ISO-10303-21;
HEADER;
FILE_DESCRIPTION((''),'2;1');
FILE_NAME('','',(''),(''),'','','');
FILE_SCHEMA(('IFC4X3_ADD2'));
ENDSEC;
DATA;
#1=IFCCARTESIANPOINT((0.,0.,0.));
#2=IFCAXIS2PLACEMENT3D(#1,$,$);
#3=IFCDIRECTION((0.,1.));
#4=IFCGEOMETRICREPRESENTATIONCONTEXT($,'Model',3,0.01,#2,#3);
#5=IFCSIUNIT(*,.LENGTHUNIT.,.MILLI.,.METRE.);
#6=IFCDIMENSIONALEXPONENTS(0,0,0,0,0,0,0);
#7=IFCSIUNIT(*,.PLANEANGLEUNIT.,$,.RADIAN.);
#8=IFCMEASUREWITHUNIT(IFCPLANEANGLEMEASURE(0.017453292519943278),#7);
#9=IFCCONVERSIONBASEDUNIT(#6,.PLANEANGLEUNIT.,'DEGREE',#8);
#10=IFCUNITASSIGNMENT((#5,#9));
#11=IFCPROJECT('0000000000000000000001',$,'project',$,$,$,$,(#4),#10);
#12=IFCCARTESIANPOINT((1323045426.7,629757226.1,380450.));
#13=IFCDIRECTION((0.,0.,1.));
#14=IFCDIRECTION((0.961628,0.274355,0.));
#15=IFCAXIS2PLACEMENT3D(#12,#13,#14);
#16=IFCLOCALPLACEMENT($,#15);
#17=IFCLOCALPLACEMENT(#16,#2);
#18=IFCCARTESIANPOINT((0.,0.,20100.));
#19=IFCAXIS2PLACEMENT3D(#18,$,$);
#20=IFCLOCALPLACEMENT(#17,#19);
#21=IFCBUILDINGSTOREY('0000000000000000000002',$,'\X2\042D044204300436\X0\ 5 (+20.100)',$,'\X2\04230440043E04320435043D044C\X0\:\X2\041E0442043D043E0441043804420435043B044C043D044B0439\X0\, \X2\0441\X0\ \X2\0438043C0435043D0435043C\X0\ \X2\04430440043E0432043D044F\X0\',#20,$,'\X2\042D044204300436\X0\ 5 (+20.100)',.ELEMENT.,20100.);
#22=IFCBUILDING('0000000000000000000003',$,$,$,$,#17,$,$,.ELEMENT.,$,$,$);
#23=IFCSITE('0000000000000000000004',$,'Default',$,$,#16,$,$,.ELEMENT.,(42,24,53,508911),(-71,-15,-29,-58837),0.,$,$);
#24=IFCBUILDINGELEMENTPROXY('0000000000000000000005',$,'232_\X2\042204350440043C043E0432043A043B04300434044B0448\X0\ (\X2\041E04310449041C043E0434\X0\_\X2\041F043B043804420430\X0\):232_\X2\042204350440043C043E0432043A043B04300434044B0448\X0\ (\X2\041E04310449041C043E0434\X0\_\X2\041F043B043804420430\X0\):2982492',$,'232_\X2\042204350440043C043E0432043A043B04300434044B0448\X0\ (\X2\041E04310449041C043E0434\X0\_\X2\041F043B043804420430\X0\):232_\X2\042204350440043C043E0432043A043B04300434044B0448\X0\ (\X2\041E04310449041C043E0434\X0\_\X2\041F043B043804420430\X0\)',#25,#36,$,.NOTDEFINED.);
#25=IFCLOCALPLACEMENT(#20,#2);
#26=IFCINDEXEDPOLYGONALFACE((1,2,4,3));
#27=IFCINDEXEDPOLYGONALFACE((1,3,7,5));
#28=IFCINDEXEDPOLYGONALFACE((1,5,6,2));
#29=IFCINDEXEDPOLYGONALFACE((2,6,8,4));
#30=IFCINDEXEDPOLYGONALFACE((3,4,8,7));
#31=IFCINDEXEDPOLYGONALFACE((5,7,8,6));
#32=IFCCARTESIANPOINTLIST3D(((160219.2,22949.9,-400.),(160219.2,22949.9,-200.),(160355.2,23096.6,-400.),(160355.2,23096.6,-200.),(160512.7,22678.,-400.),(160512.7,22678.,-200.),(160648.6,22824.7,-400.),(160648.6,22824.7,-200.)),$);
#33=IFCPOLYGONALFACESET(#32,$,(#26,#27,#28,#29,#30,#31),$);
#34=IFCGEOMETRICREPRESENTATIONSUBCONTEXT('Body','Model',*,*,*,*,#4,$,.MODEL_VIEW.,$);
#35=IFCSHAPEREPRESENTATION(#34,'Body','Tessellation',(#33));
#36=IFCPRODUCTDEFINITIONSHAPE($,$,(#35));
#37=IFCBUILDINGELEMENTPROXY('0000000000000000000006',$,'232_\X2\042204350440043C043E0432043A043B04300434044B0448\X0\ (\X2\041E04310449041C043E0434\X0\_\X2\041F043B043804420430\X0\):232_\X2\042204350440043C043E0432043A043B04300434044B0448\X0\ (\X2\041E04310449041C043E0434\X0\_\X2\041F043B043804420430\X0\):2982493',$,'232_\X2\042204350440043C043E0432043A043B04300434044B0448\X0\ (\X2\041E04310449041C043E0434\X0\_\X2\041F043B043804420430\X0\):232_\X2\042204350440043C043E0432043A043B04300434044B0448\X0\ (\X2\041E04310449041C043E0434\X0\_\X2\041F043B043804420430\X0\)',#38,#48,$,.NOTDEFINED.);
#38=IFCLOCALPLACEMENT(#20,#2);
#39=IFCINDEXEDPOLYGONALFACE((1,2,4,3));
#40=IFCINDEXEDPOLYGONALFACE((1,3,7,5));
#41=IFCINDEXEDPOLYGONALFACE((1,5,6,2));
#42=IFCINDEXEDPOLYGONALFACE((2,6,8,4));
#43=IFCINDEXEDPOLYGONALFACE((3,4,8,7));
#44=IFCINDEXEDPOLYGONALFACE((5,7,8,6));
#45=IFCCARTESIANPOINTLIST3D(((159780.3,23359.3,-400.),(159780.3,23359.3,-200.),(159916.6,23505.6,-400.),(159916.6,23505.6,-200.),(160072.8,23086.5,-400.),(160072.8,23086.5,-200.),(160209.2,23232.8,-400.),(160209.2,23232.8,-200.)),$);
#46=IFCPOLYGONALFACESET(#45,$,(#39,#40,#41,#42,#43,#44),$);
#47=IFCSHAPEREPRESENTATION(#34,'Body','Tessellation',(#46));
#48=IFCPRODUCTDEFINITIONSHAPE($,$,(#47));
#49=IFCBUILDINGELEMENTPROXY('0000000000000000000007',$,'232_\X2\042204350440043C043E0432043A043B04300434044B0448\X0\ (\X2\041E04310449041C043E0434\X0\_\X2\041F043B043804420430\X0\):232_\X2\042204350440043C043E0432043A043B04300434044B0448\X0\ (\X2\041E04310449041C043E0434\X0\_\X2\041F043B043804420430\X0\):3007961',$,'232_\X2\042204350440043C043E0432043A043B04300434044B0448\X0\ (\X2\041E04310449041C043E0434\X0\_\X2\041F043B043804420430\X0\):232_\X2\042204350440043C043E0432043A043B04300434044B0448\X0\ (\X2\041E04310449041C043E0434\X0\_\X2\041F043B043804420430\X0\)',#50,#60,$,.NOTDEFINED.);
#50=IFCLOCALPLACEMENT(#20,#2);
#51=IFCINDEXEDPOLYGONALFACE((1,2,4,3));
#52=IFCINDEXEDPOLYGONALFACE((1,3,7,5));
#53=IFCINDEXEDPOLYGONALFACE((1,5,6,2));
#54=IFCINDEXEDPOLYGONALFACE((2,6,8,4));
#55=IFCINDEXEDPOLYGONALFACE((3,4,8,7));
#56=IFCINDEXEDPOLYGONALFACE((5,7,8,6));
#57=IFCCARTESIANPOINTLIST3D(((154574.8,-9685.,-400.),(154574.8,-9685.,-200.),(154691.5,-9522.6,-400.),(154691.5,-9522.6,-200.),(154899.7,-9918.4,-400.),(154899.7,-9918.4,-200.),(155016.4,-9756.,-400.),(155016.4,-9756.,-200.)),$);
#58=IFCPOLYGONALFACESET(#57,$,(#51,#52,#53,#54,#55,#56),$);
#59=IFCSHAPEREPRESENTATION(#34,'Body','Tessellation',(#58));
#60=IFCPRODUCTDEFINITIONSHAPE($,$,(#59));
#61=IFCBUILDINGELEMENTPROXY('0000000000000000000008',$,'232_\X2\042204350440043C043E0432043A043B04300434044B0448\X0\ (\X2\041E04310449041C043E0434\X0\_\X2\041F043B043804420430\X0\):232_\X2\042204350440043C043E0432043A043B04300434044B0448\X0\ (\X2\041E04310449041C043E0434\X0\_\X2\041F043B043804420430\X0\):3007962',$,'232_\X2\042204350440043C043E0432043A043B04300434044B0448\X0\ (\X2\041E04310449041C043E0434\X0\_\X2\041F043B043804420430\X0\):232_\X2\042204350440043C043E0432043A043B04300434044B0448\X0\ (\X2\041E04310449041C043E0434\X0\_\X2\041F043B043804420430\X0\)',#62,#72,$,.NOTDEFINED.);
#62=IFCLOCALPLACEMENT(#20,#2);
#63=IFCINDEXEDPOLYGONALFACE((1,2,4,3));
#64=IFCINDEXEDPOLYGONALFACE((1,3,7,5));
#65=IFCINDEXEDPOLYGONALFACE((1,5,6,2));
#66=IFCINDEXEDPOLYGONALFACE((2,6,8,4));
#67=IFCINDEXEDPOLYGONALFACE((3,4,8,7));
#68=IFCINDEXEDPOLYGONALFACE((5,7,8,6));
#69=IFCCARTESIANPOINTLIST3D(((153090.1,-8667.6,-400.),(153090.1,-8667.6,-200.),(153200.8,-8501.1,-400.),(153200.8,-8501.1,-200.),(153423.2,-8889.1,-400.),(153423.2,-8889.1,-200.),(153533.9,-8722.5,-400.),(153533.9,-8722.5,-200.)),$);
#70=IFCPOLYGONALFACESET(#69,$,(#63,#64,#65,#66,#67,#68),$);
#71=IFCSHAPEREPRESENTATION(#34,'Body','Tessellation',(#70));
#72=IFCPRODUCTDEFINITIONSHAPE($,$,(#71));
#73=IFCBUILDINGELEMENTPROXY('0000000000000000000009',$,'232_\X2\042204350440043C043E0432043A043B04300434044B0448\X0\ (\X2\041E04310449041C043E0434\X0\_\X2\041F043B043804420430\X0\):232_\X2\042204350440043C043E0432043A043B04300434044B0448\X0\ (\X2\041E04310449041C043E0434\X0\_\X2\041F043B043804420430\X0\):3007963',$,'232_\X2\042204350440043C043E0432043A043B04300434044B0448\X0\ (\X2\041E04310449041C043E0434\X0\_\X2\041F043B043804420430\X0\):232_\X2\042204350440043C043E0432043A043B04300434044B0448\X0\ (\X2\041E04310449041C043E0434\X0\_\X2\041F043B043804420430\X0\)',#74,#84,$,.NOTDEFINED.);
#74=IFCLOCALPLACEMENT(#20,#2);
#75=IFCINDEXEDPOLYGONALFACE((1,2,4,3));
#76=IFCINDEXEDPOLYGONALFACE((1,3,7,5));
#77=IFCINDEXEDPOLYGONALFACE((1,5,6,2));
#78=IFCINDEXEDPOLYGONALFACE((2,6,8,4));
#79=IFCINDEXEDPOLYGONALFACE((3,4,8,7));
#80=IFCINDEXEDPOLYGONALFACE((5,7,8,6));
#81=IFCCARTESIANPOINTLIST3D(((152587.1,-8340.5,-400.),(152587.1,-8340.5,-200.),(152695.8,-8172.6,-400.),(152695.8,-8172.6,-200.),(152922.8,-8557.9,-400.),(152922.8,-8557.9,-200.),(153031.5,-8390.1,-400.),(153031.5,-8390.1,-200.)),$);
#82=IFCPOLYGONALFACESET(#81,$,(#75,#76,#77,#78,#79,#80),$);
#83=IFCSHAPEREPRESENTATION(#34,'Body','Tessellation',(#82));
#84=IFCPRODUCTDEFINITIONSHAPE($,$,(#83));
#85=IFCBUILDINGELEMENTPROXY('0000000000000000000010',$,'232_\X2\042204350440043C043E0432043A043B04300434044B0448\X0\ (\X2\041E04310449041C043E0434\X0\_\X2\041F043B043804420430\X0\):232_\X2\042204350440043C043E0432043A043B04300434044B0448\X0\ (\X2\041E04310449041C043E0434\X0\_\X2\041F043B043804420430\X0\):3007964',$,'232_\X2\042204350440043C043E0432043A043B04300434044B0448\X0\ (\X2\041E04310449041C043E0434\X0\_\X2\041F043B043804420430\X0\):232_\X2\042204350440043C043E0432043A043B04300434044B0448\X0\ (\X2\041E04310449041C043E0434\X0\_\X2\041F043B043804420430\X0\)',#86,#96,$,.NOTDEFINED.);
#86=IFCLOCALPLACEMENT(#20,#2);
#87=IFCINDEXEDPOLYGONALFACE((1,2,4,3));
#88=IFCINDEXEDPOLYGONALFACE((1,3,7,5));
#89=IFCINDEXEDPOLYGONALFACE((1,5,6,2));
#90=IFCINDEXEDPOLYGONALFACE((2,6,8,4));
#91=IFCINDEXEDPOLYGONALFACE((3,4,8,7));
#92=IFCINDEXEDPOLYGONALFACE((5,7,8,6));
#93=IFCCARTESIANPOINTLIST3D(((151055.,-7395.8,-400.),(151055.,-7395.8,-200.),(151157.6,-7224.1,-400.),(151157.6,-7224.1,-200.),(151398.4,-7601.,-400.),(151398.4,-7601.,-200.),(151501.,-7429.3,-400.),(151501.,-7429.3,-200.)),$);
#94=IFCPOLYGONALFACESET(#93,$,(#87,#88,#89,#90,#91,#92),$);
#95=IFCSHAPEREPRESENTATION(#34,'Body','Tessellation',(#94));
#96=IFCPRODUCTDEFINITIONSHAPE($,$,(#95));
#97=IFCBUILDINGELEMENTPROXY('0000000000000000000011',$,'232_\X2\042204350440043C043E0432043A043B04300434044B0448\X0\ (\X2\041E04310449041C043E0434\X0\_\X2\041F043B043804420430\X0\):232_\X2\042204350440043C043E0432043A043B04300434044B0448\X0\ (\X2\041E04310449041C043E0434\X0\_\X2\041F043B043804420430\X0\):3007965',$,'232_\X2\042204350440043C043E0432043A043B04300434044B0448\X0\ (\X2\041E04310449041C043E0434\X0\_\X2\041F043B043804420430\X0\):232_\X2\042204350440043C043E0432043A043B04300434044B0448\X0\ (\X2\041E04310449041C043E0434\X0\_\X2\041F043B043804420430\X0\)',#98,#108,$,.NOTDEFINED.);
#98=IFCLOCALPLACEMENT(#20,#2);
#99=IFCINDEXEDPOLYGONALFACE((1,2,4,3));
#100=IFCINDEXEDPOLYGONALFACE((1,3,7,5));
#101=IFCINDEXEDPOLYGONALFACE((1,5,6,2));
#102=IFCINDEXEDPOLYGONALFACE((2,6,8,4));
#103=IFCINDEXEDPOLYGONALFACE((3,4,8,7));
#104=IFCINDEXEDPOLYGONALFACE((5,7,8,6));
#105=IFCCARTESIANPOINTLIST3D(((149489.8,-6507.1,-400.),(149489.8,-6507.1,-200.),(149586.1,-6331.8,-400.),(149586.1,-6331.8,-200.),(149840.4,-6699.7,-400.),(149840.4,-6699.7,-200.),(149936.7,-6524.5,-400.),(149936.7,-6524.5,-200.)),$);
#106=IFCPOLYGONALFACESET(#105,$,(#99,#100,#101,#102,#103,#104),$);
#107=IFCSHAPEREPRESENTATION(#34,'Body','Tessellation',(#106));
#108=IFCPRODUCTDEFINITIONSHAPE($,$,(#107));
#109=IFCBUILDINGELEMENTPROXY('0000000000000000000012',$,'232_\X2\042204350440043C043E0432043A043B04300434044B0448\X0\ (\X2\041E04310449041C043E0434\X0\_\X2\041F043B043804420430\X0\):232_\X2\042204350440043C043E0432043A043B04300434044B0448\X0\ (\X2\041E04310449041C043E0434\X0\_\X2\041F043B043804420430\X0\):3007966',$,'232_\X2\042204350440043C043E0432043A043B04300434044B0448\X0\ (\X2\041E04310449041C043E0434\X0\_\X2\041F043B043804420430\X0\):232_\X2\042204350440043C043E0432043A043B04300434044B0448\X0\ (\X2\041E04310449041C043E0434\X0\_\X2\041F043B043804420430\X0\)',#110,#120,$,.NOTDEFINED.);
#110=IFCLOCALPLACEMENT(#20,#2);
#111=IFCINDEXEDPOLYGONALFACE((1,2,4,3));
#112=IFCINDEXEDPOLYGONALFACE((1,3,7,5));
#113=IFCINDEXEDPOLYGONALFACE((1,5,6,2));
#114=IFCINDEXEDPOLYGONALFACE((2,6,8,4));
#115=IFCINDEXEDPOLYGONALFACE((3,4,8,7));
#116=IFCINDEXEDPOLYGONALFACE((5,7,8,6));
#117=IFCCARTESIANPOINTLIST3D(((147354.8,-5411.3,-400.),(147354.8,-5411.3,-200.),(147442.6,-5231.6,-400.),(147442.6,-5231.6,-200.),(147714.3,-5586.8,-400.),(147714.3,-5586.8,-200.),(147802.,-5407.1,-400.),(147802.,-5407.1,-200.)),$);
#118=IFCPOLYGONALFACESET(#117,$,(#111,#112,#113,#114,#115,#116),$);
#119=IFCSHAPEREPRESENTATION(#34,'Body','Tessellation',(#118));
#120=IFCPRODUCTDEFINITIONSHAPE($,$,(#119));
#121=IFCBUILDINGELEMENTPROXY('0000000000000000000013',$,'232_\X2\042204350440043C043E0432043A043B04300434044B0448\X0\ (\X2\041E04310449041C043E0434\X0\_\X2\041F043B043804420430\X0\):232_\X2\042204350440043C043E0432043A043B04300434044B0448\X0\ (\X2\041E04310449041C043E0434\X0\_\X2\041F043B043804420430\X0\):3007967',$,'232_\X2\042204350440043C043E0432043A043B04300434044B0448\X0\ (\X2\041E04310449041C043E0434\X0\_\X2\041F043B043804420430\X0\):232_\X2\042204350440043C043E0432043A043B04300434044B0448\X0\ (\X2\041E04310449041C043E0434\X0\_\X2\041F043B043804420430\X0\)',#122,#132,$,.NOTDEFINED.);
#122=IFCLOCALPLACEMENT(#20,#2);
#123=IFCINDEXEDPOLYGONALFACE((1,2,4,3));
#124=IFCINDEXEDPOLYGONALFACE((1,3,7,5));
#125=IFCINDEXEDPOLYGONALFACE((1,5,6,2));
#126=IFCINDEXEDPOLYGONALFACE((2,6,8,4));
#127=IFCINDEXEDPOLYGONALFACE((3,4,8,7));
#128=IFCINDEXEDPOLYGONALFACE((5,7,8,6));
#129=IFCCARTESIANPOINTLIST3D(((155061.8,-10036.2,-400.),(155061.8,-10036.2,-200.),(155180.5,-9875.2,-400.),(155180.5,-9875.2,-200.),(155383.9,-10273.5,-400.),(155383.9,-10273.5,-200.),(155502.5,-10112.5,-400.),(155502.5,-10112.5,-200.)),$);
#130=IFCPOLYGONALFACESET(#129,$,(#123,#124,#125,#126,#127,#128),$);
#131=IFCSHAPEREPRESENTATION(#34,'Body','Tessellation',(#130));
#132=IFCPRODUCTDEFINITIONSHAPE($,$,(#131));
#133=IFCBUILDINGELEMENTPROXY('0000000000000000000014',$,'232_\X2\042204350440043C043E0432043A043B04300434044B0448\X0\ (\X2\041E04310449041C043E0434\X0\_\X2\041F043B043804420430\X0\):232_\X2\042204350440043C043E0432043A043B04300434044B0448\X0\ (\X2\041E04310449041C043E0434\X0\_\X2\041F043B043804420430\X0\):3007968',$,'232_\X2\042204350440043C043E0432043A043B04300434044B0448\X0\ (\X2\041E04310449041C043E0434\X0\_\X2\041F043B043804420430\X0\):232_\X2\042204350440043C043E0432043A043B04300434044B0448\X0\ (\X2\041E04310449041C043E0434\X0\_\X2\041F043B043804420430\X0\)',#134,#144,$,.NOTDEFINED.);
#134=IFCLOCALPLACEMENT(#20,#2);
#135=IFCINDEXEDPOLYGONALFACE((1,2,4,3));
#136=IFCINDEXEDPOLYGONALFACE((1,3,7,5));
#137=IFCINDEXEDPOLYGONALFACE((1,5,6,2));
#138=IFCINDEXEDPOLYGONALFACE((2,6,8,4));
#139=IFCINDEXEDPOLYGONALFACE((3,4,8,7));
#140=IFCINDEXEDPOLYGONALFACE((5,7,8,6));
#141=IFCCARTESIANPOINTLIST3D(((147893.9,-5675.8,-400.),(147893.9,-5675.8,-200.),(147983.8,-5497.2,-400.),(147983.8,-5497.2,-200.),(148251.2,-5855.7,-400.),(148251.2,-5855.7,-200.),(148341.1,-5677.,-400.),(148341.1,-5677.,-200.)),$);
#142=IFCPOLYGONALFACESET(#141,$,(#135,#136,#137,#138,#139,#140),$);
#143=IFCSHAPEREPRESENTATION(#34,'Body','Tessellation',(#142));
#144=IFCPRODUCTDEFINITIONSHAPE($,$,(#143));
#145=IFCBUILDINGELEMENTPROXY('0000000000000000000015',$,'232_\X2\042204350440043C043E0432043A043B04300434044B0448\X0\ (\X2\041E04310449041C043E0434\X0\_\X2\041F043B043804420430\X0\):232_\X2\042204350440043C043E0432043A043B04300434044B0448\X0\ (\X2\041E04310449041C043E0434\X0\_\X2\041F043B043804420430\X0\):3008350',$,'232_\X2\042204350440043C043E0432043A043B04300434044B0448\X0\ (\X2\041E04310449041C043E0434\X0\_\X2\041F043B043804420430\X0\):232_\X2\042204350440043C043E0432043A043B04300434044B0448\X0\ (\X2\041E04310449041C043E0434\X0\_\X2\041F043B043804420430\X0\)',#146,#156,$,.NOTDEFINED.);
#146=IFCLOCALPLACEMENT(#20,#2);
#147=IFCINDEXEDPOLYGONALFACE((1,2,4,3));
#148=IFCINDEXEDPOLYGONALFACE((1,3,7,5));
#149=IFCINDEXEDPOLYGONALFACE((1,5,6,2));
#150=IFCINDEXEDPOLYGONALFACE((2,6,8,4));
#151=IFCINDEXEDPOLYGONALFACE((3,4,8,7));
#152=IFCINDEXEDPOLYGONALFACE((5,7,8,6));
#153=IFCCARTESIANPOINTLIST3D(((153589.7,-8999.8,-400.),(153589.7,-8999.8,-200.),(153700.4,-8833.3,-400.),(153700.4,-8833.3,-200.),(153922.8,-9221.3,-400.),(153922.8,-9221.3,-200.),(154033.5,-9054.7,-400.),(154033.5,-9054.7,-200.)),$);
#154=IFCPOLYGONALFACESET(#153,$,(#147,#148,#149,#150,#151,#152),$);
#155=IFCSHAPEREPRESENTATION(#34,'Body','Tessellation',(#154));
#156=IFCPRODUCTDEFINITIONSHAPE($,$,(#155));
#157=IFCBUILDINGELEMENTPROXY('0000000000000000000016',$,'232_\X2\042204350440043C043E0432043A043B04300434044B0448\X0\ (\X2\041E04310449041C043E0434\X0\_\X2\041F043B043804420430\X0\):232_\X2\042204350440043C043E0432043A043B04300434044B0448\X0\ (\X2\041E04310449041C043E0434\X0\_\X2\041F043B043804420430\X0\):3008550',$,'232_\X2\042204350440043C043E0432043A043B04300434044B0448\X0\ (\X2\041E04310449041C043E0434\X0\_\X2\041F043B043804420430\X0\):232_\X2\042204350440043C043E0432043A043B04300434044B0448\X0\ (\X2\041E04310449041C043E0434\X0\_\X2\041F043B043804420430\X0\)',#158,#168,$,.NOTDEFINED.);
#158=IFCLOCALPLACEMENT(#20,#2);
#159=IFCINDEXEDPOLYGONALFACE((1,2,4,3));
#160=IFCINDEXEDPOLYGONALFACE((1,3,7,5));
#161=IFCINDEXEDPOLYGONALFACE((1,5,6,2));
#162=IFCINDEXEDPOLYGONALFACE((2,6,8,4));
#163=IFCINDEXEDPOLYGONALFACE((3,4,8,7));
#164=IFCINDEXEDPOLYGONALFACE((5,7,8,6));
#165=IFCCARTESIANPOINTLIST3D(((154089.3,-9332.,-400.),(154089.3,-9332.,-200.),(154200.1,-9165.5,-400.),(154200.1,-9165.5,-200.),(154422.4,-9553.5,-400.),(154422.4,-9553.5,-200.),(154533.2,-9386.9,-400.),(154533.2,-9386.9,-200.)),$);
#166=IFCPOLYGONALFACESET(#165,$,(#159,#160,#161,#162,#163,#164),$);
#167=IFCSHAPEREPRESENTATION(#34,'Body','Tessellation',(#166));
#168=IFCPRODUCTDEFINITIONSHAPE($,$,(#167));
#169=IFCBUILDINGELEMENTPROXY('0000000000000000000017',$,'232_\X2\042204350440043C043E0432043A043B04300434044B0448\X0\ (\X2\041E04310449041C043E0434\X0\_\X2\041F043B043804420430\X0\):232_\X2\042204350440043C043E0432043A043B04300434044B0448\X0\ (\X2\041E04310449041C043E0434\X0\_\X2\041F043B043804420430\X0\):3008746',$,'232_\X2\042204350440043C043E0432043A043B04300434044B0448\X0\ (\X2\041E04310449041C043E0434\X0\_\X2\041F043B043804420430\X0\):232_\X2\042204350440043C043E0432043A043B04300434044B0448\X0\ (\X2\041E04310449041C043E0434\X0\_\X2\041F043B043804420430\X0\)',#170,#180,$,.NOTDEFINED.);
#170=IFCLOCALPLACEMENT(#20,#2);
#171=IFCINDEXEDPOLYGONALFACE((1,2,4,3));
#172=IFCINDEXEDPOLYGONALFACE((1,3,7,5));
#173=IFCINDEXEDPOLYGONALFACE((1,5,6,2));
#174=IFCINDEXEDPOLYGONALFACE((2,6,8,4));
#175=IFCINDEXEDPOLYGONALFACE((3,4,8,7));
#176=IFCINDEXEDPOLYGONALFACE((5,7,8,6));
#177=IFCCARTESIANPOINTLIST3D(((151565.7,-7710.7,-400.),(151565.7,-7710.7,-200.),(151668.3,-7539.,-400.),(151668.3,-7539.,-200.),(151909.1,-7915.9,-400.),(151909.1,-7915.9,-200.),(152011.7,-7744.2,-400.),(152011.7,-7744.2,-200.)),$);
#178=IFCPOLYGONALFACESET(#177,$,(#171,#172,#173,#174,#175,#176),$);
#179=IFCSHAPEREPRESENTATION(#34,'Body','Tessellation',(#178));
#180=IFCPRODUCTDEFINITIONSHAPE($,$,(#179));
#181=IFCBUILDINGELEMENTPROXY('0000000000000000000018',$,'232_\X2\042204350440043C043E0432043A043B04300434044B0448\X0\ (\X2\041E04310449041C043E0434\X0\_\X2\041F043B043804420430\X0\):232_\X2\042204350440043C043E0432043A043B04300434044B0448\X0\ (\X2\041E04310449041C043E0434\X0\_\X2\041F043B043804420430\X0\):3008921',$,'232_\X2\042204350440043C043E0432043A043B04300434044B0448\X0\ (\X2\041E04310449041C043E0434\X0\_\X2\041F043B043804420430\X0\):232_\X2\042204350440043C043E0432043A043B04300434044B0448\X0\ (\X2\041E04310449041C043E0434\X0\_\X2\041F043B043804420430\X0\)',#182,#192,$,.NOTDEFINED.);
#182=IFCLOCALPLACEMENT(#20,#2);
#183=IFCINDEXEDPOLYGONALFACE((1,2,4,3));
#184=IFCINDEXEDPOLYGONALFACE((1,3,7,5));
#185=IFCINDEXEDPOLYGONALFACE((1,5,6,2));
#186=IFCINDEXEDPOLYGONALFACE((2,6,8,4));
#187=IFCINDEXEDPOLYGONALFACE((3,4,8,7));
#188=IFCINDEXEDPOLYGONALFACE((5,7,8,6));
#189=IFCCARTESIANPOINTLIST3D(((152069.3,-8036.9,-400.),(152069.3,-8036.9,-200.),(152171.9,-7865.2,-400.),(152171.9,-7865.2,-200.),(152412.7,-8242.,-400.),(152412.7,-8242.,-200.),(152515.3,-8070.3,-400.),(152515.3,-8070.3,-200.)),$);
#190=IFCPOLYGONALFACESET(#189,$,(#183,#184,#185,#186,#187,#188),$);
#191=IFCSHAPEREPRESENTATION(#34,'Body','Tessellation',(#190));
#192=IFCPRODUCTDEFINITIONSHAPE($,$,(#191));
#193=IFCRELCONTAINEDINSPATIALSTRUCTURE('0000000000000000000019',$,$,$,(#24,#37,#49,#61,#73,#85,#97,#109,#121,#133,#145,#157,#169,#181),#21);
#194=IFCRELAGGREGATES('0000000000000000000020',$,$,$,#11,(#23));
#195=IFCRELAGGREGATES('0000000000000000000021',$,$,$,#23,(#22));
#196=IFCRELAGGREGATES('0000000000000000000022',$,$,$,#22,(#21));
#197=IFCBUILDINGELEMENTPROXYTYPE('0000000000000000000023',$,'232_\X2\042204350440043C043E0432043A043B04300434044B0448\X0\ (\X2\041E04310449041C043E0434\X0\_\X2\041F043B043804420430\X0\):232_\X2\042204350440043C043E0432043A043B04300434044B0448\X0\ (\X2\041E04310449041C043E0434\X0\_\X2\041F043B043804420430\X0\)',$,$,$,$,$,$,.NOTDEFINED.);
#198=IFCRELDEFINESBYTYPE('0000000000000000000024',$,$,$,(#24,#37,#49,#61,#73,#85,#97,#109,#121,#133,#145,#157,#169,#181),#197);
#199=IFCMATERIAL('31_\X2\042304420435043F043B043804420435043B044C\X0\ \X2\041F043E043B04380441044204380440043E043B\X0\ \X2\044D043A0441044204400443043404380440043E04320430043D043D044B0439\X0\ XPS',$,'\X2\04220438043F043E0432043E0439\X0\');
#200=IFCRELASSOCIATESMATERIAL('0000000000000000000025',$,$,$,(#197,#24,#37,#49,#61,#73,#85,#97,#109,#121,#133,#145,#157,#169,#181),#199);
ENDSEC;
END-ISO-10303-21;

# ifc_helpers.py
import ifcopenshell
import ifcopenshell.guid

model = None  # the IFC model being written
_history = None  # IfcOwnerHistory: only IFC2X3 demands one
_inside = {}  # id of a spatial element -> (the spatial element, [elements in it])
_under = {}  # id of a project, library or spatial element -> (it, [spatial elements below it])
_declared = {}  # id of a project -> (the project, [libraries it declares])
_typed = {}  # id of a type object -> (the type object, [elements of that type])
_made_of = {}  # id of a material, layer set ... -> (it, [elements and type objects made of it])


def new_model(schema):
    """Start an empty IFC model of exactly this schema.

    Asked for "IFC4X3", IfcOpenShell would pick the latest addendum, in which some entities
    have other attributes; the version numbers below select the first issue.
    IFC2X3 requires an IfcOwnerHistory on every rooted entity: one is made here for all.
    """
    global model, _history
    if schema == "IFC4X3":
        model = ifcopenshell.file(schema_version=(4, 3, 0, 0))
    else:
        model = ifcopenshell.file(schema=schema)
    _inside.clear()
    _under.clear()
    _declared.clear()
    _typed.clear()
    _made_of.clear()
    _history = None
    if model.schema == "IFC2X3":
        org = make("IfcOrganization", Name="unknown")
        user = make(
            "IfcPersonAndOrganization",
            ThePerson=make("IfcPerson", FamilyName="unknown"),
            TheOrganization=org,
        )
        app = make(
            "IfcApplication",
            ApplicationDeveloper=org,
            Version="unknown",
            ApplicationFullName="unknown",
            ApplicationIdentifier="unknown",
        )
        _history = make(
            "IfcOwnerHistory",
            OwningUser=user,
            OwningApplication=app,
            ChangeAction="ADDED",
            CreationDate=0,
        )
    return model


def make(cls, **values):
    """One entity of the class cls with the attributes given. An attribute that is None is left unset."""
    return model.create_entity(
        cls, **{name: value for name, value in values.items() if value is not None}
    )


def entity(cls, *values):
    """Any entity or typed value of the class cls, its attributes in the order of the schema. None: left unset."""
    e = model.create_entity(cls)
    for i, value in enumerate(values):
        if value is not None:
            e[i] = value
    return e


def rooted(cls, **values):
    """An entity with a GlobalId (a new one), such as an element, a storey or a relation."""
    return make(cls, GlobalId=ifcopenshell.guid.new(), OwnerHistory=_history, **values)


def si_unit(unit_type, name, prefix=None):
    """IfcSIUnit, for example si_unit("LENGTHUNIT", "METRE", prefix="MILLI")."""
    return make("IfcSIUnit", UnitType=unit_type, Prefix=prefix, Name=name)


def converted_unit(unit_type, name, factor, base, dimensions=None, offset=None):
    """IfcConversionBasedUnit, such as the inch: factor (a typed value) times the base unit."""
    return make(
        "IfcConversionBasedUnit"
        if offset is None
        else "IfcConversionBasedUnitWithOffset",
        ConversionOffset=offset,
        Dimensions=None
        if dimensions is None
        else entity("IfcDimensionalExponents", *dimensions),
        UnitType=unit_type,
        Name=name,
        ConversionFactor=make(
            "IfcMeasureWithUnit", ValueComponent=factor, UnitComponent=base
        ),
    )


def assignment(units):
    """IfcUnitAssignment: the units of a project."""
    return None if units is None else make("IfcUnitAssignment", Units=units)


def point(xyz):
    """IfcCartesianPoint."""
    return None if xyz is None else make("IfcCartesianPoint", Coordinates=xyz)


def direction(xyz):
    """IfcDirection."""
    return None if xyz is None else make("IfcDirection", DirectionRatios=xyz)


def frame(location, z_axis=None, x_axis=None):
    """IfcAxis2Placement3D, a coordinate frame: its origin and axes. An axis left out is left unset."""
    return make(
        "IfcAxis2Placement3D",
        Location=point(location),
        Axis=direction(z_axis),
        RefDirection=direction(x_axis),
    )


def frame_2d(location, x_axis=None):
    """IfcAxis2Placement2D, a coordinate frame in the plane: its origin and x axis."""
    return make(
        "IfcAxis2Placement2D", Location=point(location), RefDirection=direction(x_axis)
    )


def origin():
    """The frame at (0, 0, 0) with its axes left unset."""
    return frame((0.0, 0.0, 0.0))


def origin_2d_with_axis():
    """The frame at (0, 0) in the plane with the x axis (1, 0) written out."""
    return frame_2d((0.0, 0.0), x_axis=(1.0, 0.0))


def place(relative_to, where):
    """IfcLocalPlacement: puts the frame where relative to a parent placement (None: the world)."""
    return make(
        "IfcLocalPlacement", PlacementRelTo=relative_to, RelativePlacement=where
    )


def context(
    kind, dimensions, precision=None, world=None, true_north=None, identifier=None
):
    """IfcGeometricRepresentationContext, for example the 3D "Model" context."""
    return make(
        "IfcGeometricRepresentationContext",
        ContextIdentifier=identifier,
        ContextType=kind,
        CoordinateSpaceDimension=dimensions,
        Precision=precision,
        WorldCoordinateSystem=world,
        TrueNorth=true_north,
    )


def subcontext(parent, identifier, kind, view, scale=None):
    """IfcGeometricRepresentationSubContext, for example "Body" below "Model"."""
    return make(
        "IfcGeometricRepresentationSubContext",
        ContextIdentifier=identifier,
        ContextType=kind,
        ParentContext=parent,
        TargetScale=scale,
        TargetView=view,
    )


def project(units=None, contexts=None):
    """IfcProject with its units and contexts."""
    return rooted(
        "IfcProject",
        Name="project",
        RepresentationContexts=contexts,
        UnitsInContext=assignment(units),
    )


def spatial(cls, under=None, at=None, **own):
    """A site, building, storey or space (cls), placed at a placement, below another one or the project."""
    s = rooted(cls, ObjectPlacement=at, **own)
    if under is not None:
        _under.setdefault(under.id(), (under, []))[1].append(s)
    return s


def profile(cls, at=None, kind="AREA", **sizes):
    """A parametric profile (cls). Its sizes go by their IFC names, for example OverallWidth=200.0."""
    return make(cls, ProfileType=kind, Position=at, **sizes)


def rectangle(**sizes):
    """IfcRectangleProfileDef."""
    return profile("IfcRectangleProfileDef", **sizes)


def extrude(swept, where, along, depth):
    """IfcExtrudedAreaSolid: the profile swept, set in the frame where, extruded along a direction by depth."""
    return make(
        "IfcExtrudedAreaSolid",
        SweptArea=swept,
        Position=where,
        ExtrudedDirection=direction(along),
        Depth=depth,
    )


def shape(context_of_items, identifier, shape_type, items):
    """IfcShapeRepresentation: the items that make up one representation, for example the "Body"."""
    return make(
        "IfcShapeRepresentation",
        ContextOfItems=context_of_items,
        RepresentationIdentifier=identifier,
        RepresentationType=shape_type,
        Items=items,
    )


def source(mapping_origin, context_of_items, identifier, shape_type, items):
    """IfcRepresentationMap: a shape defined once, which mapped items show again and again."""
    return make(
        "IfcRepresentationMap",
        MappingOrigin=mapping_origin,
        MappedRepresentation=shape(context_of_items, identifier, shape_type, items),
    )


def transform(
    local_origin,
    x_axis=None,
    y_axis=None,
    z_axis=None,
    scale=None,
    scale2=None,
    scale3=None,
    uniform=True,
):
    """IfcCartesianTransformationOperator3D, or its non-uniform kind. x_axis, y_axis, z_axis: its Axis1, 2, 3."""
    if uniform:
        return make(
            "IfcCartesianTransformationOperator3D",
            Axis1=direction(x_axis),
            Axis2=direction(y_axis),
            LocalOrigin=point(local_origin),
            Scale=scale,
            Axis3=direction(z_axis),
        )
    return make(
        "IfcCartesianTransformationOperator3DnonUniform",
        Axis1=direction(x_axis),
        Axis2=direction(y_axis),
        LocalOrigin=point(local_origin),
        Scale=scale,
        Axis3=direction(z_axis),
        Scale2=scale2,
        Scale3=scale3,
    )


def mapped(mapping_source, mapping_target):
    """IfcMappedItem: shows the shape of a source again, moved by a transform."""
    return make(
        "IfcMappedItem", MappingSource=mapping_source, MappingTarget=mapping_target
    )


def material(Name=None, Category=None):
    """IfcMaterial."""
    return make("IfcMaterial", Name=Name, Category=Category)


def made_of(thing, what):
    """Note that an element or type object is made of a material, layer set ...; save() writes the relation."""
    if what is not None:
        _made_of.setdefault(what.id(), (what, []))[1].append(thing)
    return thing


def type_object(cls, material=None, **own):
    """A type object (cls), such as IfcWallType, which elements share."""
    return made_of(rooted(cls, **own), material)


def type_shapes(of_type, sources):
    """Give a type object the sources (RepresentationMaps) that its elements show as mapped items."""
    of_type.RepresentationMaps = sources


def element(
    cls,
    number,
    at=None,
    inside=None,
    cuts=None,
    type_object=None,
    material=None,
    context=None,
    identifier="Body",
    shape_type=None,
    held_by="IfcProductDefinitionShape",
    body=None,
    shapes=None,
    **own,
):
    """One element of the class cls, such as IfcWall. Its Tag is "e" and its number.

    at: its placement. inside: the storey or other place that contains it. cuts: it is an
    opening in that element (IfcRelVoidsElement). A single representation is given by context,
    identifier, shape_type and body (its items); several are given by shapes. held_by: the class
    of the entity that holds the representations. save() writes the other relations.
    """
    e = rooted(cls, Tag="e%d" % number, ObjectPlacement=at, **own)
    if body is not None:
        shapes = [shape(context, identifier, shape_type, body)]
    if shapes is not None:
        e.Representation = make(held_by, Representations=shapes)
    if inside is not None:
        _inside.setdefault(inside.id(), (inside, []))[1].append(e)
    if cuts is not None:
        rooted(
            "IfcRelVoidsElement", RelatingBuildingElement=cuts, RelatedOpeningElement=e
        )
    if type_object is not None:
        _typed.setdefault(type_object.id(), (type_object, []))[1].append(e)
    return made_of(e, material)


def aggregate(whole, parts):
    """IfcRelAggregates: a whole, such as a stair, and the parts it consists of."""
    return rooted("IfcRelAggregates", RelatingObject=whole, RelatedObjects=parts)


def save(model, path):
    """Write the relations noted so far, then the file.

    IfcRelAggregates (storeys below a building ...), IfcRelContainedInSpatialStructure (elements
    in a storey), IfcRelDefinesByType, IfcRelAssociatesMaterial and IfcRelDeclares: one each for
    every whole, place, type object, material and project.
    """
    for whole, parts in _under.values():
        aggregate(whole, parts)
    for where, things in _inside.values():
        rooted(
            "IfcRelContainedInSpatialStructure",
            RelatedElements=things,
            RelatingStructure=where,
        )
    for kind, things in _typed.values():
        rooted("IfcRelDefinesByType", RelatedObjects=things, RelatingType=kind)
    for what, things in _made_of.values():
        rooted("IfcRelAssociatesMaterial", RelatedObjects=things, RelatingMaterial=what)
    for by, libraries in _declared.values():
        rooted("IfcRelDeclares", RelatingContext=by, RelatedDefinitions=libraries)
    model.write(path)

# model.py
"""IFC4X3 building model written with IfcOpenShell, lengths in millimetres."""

from ifc_helpers import new_model, entity, si_unit, converted_unit, direction, frame, origin, origin_2d_with_axis, place, context, subcontext, project, spatial, rectangle, extrude, source, transform, mapped, material, type_object, type_shapes, element, save


model = new_model("IFC4X3")

# Units and contexts
model_context = context("Model", 3, precision=0.01, world=origin(), true_north=direction((0.0, 1.0)))
body_context = subcontext(model_context, "Body", "Model", "MODEL_VIEW")
ifc_project = project(units=[si_unit("LENGTHUNIT", "METRE", prefix="MILLI"), converted_unit("PLANEANGLEUNIT", "DEGREE", entity("IfcPlaneAngleMeasure", 0.017453292519943278), si_unit("PLANEANGLEUNIT", "RADIAN"), dimensions=[0, 0, 0, 0, 0, 0, 0])], contexts=[model_context])

# Site, building, storey
site_placement = place(None, frame((1323045426.7, 629757226.1, 380450.0), z_axis=(0.0, 0.0, 1.0), x_axis=(0.961628, 0.274355, 0.0)))
site = spatial("IfcSite", under=ifc_project, at=site_placement, Name="Default", CompositionType="ELEMENT", RefLatitude=(42, 24, 53, 508911), RefLongitude=(-71, -15, -29, -58837), RefElevation=0.0)
building_placement = place(site_placement, origin())
building = spatial("IfcBuilding", under=site, at=building_placement, CompositionType="ELEMENT")
storey_placement = place(building_placement, frame((0.0, 0.0, 20100.0)))
storey = spatial("IfcBuildingStorey", under=building, at=storey_placement, Name="Этаж 5 (+20.100)", ObjectType="Уровень:Относительный, с именем уровня", LongName="Этаж 5 (+20.100)", CompositionType="ELEMENT", Elevation=20100.0)

# Building element proxies
ifc_material_1 = material(Name="31_Утеплитель Полистирол экструдированный XPS", Category="Типовой")
building_element_proxy_type_1 = type_object("IfcBuildingElementProxyType", Name="232_Термовкладыш (ОбщМод_Плита):232_Термовкладыш (ОбщМод_Плита)", PredefinedType="NOTDEFINED", material=ifc_material_1)
shared_shape_1 = source(origin(), body_context, "Body", "SweptSolid", [
    extrude(rectangle(XDim=400.0, YDim=200.0, at=origin_2d_with_axis()), frame((200.0, 0.0, -200.0), z_axis=(0.0, 0.0, 1.0), x_axis=(-1.0, 0.0, 0.0)), (0.0, 0.0, 1.0), 200.0),
])
type_shapes(building_element_proxy_type_1, [shared_shape_1])
for number, where, z_axis, x_axis, name in (
    (1, (160580.6, 22751.4, -200.0), (0.0, 0.0, 1.0), (-0.733608, 0.679572, 0.0), "232_Термовкладыш (ОбщМод_Плита):232_Термовкладыш (ОбщМод_Плита):2982492"),
    (2, (160141.0, 23159.7, -200.0), (0.0, 0.0, 1.0), (-0.731439, 0.681907, 0.0), "232_Термовкладыш (ОбщМод_Плита):232_Термовкладыш (ОбщМод_Плита):2982493"),
    (3, (154633.2, -9603.8, -200.0), (0.0, 0.0, 1.0), (0.812178, -0.583409, 0.0), "232_Термовкладыш (ОбщМод_Плита):232_Термовкладыш (ОбщМод_Плита):3007961"),
    (4, (153145.4, -8584.3, -200.0), (0.0, 0.0, 1.0), (0.832738, -0.553667, 0.0), "232_Термовкладыш (ОбщМод_Плита):232_Термовкладыш (ОбщМод_Плита):3007962"),
    (5, (152641.4, -8256.6, -200.0), (0.0, 0.0, 1.0), (0.839351, -0.54359, 0.0), "232_Термовкладыш (ОбщМод_Плита):232_Термовкладыш (ОбщМод_Плита):3007963"),
    (6, (151106.3, -7310.0, -200.0), (0.0, 0.0, 1.0), (0.858454, -0.512891, 0.0), "232_Термовкладыш (ОбщМод_Плита):232_Термовкладыш (ОбщМод_Плита):3007964"),
    (7, (149538.0, -6419.5, -200.0), (0.0, 0.0, 1.0), (0.876434, -0.481521, 0.0), "232_Термовкладыш (ОбщМод_Плита):232_Термовкладыш (ОбщМод_Плита):3007965"),
    (8, (147398.7, -5321.5, -200.0), (0.0, 0.0, 1.0), (0.898622, -0.438723, 0.0), "232_Термовкладыш (ОбщМод_Плита):232_Термовкладыш (ОбщМод_Плита):3007966"),
    (9, (155121.2, -9955.7, -200.0), (0.0, 0.0, 1.0), (0.805088, -0.593156, 0.0), "232_Термовкладыш (ОбщМод_Плита):232_Термовкладыш (ОбщМод_Плита):3007967"),
    (10, (147938.8, -5586.5, -200.0), (0.0, 0.0, 1.0), (0.893269, -0.449522, 0.0), "232_Термовкладыш (ОбщМод_Плита):232_Термовкладыш (ОбщМод_Плита):3007968"),
    (11, (153645.1, -8916.5, -200.0), (0.0, 0.0, 1.0), (0.832738, -0.553667, 0.0), "232_Термовкладыш (ОбщМод_Плита):232_Термовкладыш (ОбщМод_Плита):3008350"),
    (12, (154144.7, -9248.7, -200.0), (0.0, 0.0, 1.0), (0.832738, -0.553667, 0.0), "232_Термовкладыш (ОбщМод_Плита):232_Термовкладыш (ОбщМод_Плита):3008550"),
    (13, (151617.0, -7624.9, -200.0), (0.0, 0.0, 1.0), (0.858454, -0.512891, 0.0), "232_Термовкладыш (ОбщМод_Плита):232_Термовкладыш (ОбщМод_Плита):3008746"),
    (14, (152120.6, -7951.0, -200.0), (0.0, 0.0, 1.0), (0.858454, -0.512891, 0.0), "232_Термовкладыш (ОбщМод_Плита):232_Термовкладыш (ОбщМод_Плита):3008921"),
):
    element("IfcBuildingElementProxy", number, at=place(storey_placement, frame(where, z_axis=z_axis, x_axis=x_axis)), inside=storey, type_object=building_element_proxy_type_1, material=ifc_material_1, Name=name, ObjectType="232_Термовкладыш (ОбщМод_Плита):232_Термовкладыш (ОбщМод_Плита)", PredefinedType="NOTDEFINED", context=body_context, shape_type="MappedRepresentation", body=[
        mapped(shared_shape_1, transform((0.0, 0.0, 0.0), scale=1.0)),
    ])

save(model, "model.ifc")
